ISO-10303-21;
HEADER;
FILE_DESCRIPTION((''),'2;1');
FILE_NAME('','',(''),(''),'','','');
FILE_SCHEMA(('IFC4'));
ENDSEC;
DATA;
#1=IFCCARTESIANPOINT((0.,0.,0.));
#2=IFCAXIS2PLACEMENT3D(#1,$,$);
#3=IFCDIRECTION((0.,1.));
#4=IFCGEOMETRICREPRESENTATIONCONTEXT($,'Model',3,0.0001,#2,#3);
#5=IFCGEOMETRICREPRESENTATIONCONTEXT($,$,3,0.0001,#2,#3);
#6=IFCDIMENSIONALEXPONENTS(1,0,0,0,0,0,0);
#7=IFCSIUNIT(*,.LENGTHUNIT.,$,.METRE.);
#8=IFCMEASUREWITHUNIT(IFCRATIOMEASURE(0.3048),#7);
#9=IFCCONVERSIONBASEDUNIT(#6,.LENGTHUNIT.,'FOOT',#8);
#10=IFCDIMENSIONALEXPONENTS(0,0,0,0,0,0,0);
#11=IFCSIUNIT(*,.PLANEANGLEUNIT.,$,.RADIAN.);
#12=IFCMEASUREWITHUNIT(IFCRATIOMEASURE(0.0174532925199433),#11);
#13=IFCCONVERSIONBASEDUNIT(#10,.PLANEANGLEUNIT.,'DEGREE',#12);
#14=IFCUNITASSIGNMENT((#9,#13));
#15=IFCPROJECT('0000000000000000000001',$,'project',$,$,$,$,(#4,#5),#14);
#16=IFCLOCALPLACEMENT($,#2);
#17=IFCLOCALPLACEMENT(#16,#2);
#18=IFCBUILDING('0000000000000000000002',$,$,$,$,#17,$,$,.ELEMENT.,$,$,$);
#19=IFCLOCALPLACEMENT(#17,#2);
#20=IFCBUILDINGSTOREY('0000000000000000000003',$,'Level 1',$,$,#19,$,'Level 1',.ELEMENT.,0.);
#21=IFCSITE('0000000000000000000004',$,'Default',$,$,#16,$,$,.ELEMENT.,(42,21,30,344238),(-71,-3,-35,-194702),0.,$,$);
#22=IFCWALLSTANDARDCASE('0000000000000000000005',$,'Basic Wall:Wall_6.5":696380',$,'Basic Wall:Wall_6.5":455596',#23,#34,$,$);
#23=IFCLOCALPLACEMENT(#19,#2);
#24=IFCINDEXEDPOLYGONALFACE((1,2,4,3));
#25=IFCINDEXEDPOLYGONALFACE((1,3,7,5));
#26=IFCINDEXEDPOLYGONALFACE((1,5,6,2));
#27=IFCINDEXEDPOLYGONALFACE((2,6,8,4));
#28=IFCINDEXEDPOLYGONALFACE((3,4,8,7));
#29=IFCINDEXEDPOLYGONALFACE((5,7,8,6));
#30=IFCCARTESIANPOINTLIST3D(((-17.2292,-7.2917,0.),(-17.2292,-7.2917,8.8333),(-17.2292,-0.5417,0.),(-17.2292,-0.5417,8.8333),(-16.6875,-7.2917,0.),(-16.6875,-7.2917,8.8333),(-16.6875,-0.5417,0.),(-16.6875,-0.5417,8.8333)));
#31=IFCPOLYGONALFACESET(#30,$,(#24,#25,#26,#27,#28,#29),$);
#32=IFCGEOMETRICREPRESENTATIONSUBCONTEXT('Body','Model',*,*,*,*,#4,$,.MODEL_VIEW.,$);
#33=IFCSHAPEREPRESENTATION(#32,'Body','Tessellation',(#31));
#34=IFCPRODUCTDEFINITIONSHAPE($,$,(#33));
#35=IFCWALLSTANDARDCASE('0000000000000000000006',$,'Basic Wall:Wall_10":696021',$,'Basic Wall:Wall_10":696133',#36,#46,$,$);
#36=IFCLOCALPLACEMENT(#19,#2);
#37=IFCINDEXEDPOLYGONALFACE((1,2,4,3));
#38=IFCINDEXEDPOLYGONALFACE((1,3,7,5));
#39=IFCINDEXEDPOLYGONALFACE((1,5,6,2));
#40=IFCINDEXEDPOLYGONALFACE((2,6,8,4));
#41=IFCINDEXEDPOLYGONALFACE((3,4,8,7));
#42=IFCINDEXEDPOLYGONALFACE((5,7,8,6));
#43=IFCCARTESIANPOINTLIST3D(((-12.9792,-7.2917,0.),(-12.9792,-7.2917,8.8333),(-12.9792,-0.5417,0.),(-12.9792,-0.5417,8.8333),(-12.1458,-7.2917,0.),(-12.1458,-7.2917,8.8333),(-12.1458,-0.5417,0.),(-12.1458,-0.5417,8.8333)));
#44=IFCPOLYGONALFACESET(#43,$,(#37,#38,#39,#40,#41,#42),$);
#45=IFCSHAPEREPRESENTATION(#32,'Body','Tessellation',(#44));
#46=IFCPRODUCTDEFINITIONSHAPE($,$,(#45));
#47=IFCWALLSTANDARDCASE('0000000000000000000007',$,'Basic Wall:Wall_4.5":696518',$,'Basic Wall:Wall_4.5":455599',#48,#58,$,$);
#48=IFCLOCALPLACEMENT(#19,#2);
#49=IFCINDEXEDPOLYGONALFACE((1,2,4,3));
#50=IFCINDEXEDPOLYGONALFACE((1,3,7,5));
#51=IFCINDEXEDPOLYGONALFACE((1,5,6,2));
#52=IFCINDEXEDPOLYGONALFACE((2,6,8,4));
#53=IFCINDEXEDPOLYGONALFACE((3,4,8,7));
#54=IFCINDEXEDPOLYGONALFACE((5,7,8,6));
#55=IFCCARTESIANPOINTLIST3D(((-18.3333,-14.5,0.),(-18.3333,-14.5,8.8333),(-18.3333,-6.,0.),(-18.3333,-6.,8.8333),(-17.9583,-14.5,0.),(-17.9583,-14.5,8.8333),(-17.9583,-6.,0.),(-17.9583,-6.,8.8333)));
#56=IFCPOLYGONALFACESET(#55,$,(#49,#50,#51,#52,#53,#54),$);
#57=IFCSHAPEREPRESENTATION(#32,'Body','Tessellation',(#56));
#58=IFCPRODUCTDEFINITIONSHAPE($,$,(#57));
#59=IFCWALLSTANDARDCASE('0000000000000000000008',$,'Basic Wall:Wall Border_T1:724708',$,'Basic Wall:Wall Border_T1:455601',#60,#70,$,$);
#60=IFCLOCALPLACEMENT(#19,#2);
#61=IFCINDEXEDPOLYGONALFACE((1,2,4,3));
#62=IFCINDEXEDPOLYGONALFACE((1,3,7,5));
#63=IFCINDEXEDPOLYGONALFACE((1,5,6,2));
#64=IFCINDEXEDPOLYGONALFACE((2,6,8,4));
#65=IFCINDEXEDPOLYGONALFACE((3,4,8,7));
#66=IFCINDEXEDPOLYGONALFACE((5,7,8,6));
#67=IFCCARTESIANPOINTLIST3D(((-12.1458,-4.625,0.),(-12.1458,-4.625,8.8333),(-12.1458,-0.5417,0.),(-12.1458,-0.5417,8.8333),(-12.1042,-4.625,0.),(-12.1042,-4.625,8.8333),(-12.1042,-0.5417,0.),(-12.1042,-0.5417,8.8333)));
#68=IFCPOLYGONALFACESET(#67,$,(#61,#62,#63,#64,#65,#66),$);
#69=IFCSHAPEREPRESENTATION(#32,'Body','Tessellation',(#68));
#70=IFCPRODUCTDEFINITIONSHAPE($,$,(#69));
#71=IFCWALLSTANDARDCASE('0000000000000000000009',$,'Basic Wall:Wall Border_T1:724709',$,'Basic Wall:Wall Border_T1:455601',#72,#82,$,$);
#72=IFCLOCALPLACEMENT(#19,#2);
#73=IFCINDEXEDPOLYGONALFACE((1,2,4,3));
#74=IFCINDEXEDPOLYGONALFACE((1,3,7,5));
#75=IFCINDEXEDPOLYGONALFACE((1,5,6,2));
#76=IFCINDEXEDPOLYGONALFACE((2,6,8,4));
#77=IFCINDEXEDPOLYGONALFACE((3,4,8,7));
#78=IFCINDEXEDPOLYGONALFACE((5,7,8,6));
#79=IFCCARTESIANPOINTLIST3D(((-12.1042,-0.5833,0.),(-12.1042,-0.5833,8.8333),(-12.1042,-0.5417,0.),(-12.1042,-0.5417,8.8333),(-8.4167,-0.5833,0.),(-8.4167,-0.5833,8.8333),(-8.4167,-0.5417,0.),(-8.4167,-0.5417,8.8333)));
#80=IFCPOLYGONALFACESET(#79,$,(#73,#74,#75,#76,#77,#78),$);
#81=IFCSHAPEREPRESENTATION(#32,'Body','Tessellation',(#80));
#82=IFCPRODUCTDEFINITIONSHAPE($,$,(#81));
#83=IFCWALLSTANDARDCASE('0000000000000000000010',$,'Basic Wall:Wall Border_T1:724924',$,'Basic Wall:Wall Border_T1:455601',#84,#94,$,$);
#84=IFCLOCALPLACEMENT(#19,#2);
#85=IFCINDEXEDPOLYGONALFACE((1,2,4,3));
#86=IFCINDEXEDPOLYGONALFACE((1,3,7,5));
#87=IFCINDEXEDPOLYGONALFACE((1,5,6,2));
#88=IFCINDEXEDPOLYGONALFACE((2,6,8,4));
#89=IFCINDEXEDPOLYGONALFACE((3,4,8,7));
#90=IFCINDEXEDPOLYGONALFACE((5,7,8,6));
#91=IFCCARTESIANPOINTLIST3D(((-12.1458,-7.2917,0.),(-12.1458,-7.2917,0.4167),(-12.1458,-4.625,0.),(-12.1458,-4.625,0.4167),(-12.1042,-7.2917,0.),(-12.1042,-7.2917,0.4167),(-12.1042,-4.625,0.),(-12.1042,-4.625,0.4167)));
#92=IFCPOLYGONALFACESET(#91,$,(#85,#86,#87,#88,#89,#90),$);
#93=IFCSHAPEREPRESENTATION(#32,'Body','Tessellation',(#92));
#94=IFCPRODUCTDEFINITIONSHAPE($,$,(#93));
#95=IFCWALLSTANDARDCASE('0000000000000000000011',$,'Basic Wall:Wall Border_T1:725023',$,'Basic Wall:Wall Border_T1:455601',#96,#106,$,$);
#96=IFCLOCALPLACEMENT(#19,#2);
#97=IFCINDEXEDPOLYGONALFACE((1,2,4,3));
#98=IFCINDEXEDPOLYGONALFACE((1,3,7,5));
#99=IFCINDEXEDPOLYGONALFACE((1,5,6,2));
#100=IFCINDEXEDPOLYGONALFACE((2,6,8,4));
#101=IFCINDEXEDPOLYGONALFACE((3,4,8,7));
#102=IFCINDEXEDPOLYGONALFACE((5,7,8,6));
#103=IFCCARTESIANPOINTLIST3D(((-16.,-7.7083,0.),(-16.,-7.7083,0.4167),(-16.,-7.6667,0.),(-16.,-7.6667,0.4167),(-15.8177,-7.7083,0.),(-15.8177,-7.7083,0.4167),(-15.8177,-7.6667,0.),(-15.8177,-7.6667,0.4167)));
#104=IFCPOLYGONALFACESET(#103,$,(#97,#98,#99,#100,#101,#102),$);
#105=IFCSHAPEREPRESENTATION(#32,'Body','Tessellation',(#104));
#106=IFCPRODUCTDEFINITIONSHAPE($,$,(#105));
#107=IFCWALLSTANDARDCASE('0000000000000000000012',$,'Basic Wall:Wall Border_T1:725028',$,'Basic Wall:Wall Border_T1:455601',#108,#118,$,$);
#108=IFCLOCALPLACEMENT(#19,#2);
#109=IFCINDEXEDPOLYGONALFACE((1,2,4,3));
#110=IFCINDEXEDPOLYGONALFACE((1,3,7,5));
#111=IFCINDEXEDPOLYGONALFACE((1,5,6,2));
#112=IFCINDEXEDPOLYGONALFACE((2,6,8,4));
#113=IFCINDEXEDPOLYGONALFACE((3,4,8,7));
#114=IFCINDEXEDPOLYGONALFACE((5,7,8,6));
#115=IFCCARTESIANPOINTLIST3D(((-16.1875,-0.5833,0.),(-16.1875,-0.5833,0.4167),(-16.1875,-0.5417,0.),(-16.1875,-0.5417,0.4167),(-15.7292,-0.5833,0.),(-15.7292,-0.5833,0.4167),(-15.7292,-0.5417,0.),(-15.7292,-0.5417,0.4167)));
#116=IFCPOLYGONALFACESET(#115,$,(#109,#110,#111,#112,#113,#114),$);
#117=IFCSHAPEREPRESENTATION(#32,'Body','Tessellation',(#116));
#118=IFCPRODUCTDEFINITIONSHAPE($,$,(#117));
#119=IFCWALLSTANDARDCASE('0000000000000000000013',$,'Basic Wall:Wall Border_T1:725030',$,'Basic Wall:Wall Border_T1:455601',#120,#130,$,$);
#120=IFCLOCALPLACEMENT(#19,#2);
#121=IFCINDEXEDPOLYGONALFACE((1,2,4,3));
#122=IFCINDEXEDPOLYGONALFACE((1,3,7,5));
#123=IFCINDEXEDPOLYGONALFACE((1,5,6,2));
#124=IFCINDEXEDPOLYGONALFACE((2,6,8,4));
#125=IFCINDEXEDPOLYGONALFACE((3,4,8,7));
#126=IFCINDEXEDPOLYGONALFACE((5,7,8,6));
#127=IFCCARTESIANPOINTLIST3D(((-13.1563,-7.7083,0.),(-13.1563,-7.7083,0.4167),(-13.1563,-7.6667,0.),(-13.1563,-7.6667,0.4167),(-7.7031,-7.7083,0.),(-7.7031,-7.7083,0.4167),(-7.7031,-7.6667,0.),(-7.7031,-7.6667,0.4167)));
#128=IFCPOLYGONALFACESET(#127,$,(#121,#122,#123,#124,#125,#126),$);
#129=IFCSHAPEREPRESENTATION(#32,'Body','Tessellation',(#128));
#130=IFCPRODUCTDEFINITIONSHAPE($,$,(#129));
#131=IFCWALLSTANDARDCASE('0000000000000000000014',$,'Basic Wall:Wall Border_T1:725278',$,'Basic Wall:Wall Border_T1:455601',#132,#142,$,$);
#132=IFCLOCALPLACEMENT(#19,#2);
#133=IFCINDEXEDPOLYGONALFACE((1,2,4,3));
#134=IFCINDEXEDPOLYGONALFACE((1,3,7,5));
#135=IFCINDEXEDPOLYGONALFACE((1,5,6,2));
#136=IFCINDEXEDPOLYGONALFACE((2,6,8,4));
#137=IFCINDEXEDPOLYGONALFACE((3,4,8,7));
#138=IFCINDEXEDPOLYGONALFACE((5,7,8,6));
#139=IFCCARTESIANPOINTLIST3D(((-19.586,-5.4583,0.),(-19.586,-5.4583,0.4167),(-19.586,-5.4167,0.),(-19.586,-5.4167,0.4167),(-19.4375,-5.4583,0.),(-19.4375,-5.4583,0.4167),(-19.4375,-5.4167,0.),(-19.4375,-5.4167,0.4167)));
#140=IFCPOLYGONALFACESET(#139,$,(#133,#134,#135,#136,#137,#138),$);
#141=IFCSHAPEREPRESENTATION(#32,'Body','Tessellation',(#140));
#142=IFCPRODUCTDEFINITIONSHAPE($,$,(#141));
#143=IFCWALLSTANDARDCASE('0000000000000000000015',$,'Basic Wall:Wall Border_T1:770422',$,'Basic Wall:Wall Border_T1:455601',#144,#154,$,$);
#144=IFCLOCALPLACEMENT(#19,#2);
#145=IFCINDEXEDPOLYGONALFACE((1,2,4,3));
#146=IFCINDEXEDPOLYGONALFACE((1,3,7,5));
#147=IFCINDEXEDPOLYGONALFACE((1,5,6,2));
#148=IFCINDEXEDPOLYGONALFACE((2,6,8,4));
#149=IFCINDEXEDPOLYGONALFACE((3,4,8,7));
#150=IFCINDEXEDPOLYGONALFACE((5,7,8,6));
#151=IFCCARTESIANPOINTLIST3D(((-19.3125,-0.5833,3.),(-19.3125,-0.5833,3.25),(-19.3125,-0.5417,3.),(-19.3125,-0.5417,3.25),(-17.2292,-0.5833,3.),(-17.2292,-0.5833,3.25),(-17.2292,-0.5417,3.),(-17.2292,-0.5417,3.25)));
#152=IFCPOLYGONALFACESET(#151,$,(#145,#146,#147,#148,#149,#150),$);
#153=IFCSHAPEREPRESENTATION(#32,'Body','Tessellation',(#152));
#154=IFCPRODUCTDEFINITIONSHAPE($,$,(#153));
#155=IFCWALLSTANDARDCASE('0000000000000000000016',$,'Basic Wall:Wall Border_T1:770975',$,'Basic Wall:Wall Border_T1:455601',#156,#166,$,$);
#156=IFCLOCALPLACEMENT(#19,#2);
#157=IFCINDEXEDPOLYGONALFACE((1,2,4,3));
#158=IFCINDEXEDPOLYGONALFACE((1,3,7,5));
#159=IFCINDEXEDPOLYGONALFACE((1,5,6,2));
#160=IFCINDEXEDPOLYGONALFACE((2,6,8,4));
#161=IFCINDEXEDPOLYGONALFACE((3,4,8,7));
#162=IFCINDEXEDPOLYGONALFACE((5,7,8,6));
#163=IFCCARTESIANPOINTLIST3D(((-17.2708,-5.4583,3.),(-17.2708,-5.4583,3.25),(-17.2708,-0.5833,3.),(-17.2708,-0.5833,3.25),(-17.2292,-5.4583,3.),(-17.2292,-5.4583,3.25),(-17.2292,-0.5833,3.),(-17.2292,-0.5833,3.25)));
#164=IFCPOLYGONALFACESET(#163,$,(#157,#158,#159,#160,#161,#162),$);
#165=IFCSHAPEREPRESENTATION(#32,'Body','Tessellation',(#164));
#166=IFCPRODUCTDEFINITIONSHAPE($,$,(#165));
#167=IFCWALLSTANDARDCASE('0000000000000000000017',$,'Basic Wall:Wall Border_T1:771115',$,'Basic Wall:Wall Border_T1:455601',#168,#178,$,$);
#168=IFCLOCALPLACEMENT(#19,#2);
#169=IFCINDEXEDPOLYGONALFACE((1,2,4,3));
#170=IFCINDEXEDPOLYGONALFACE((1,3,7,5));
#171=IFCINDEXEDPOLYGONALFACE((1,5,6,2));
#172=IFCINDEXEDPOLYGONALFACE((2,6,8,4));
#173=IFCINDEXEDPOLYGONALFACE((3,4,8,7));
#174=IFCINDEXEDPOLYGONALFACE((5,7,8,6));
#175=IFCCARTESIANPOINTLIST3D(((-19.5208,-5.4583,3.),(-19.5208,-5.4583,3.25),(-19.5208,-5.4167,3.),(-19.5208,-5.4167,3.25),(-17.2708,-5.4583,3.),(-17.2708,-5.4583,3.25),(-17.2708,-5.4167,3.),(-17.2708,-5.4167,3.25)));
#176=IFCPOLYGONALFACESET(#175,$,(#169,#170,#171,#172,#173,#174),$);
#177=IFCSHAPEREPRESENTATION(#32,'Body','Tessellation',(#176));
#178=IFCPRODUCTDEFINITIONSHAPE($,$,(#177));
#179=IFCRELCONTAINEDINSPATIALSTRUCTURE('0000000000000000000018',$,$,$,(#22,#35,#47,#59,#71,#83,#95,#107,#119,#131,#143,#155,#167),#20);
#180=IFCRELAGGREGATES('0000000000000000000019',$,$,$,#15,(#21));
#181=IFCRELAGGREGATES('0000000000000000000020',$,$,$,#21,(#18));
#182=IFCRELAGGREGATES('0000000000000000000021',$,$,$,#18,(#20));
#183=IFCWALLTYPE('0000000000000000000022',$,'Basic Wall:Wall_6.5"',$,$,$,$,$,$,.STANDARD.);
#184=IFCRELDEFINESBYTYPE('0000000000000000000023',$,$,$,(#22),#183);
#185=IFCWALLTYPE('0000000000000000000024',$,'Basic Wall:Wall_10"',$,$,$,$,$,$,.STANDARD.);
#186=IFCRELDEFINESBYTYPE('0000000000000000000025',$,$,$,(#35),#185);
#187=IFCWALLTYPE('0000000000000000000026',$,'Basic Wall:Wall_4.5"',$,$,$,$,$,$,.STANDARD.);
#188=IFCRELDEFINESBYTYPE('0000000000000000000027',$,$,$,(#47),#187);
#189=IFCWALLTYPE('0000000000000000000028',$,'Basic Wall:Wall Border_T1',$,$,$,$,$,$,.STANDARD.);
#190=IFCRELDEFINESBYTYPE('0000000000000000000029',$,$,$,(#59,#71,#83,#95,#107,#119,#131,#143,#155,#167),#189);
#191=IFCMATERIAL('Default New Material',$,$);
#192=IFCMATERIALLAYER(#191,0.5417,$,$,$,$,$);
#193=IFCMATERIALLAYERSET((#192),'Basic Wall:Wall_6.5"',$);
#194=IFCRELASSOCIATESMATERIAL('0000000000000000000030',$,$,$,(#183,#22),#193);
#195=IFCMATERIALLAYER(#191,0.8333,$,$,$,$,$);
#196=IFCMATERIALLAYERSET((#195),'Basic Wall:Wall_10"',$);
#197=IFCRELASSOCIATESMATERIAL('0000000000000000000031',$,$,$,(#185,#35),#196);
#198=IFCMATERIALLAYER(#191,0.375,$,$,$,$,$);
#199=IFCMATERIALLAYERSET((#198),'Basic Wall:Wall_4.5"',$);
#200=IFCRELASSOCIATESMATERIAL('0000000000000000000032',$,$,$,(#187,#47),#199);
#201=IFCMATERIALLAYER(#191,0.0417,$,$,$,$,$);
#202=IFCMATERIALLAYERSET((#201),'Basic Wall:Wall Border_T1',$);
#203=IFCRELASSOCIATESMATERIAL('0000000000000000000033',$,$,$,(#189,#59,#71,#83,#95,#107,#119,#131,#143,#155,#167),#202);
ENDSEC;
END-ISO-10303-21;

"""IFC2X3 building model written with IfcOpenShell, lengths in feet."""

from ifc_helpers import new_model, entity, si_unit, converted_unit, direction, frame, frame_2d, origin, place, context, subcontext, project, spatial, rectangle, extrude, material, layer, layer_set, layer_usage, type_object, element, save


model = new_model("IFC2X3")

# Units and contexts
model_context = context("Model", 3, precision=0.0001, world=origin(), true_north=direction((0.0, 1.0)))
context_of_model = context(None, 3, precision=0.0001, world=origin(), true_north=direction((0.0, 1.0)))
body_context = subcontext(model_context, "Body", "Model", "MODEL_VIEW")
ifc_project = project(units=[converted_unit("LENGTHUNIT", "FOOT", entity("IfcRatioMeasure", 0.3048), si_unit("LENGTHUNIT", "METRE"), dimensions=[1, 0, 0, 0, 0, 0, 0]), converted_unit("PLANEANGLEUNIT", "DEGREE", entity("IfcRatioMeasure", 0.0174532925199433), si_unit("PLANEANGLEUNIT", "RADIAN"), dimensions=[0, 0, 0, 0, 0, 0, 0])], contexts=[model_context, context_of_model])

# Site, building, storey
site_placement = place(None, origin())
site = spatial("IfcSite", under=ifc_project, at=site_placement, Name="Default", CompositionType="ELEMENT", RefLatitude=(42, 21, 30, 344238), RefLongitude=(-71, -3, -35, -194702), RefElevation=0.0)
building_placement = place(site_placement, origin())
building = spatial("IfcBuilding", under=site, at=building_placement, CompositionType="ELEMENT")
storey_placement = place(building_placement, origin())
storey = spatial("IfcBuildingStorey", under=building, at=storey_placement, Name="Level 1", LongName="Level 1", CompositionType="ELEMENT", Elevation=0.0)

# Wall
ifc_material_1 = material(Name="Default New Material")
ifc_layer_1 = layer(ifc_material_1, 0.5417)
ifc_layer_set_1 = layer_set([ifc_layer_1], Name="Basic Wall:Wall_6.5\"")
ifc_layer_usage_1 = layer_usage(ifc_layer_set_1, "AXIS2", "POSITIVE", -0.2708)
wall_type_1 = type_object("IfcWallType", Name="Basic Wall:Wall_6.5\"", PredefinedType="STANDARD", material=ifc_layer_set_1)
wall_1_placement = place(storey_placement, frame((-16.9583, -7.2917, 0.0), z_axis=(0.0, 0.0, 1.0), x_axis=(0.0, 1.0, 0.0)))
element("IfcWallStandardCase", 1, at=wall_1_placement, inside=storey, type_object=wall_type_1, material=ifc_layer_usage_1, Name="Basic Wall:Wall_6.5\":696380", ObjectType="Basic Wall:Wall_6.5\":455596", context=body_context, shape_type="SweptSolid", body=[
    extrude(rectangle(XDim=6.75, YDim=0.5417, at=frame_2d((3.375, 0.0), x_axis=(-1.0, 0.0))), origin(), (0.0, 0.0, 1.0), 8.8333),
])

# Walls
ifc_layer_2 = layer(ifc_material_1, 0.8333)
ifc_layer_set_2 = layer_set([ifc_layer_2], Name="Basic Wall:Wall_10\"")
ifc_layer_usage_2 = layer_usage(ifc_layer_set_2, "AXIS2", "NEGATIVE", 0.4167)
wall_type_2 = type_object("IfcWallType", Name="Basic Wall:Wall_10\"", PredefinedType="STANDARD", material=ifc_layer_set_2)
wall_2_placement = place(storey_placement, frame((-12.5625, -7.2917, 0.0), z_axis=(0.0, 0.0, 1.0), x_axis=(0.0, 1.0, 0.0)))
element("IfcWallStandardCase", 2, at=wall_2_placement, inside=storey, type_object=wall_type_2, material=ifc_layer_usage_2, Name="Basic Wall:Wall_10\":696021", ObjectType="Basic Wall:Wall_10\":696133", context=body_context, shape_type="SweptSolid", body=[
    extrude(rectangle(XDim=6.75, YDim=0.8333, at=frame_2d((3.375, 0.0), x_axis=(-1.0, 0.0))), origin(), (0.0, 0.0, 1.0), 8.8333),
])
ifc_layer_3 = layer(ifc_material_1, 0.375)
ifc_layer_set_3 = layer_set([ifc_layer_3], Name="Basic Wall:Wall_4.5\"")
ifc_layer_usage_3 = layer_usage(ifc_layer_set_3, "AXIS2", "POSITIVE", -0.1875)
wall_type_3 = type_object("IfcWallType", Name="Basic Wall:Wall_4.5\"", PredefinedType="STANDARD", material=ifc_layer_set_3)
wall_3_placement = place(storey_placement, frame((-18.1458, -6.0, 0.0), z_axis=(0.0, 0.0, 1.0), x_axis=(0.0, -1.0, 0.0)))
element("IfcWallStandardCase", 3, at=wall_3_placement, inside=storey, type_object=wall_type_3, material=ifc_layer_usage_3, Name="Basic Wall:Wall_4.5\":696518", ObjectType="Basic Wall:Wall_4.5\":455599", context=body_context, shape_type="SweptSolid", body=[
    extrude(rectangle(XDim=8.5, YDim=0.375, at=frame_2d((4.25, 0.0), x_axis=(-1.0, 0.0))), origin(), (0.0, 0.0, 1.0), 8.8333),
])
ifc_layer_4 = layer(ifc_material_1, 0.0417)
ifc_layer_set_4 = layer_set([ifc_layer_4], Name="Basic Wall:Wall Border_T1")
ifc_layer_usage_4 = layer_usage(ifc_layer_set_4, "AXIS2", "POSITIVE", -0.0208)
wall_type_4 = type_object("IfcWallType", Name="Basic Wall:Wall Border_T1", PredefinedType="STANDARD", material=ifc_layer_set_4)
wall_4_placement = place(storey_placement, frame((-12.125, -4.625, 0.0), z_axis=(0.0, 0.0, 1.0), x_axis=(0.0, 1.0, 0.0)))
element("IfcWallStandardCase", 4, at=wall_4_placement, inside=storey, type_object=wall_type_4, material=ifc_layer_usage_4, Name="Basic Wall:Wall Border_T1:724708", ObjectType="Basic Wall:Wall Border_T1:455601", context=body_context, shape_type="SweptSolid", body=[
    extrude(rectangle(XDim=4.0833, YDim=0.0417, at=frame_2d((2.0417, 0.0), x_axis=(-1.0, 0.0))), origin(), (0.0, 0.0, 1.0), 8.8333),
])
ifc_layer_usage_5 = layer_usage(ifc_layer_set_4, "AXIS2", "POSITIVE", -0.0208)
wall_5_placement = place(storey_placement, frame((-12.1042, -0.5625, 0.0)))
element("IfcWallStandardCase", 5, at=wall_5_placement, inside=storey, type_object=wall_type_4, material=ifc_layer_usage_5, Name="Basic Wall:Wall Border_T1:724709", ObjectType="Basic Wall:Wall Border_T1:455601", context=body_context, shape_type="SweptSolid", body=[
    extrude(rectangle(XDim=3.6875, YDim=0.0417, at=frame_2d((1.8438, 0.0), x_axis=(-1.0, 0.0))), origin(), (0.0, 0.0, 1.0), 8.8333),
])
ifc_layer_usage_6 = layer_usage(ifc_layer_set_4, "AXIS2", "POSITIVE", -0.0208)
wall_6_placement = place(storey_placement, frame((-12.125, -7.2917, 0.0), z_axis=(0.0, 0.0, 1.0), x_axis=(0.0, 1.0, 0.0)))
element("IfcWallStandardCase", 6, at=wall_6_placement, inside=storey, type_object=wall_type_4, material=ifc_layer_usage_6, Name="Basic Wall:Wall Border_T1:724924", ObjectType="Basic Wall:Wall Border_T1:455601", context=body_context, shape_type="SweptSolid", body=[
    extrude(rectangle(XDim=2.6667, YDim=0.0417, at=frame_2d((1.3333, 0.0), x_axis=(-1.0, 0.0))), origin(), (0.0, 0.0, 1.0), 0.4167),
])
ifc_layer_usage_7 = layer_usage(ifc_layer_set_4, "AXIS2", "POSITIVE", -0.0208)
wall_7_placement = place(storey_placement, frame((-16.0, -7.6875, 0.0)))
element("IfcWallStandardCase", 7, at=wall_7_placement, inside=storey, type_object=wall_type_4, material=ifc_layer_usage_7, Name="Basic Wall:Wall Border_T1:725023", ObjectType="Basic Wall:Wall Border_T1:455601", context=body_context, shape_type="SweptSolid", body=[
    extrude(rectangle(XDim=0.1823, YDim=0.0417, at=frame_2d((0.0912, 0.0), x_axis=(-1.0, 0.0))), origin(), (0.0, 0.0, 1.0), 0.4167),
])
ifc_layer_usage_8 = layer_usage(ifc_layer_set_4, "AXIS2", "POSITIVE", -0.0208)
wall_8_placement = place(storey_placement, frame((-16.1875, -0.5625, 0.0)))
element("IfcWallStandardCase", 8, at=wall_8_placement, inside=storey, type_object=wall_type_4, material=ifc_layer_usage_8, Name="Basic Wall:Wall Border_T1:725028", ObjectType="Basic Wall:Wall Border_T1:455601", context=body_context, shape_type="SweptSolid", body=[
    extrude(rectangle(XDim=0.4583, YDim=0.0417, at=frame_2d((0.2292, 0.0), x_axis=(-1.0, 0.0))), origin(), (0.0, 0.0, 1.0), 0.4167),
])
ifc_layer_usage_9 = layer_usage(ifc_layer_set_4, "AXIS2", "POSITIVE", -0.0208)
wall_9_placement = place(storey_placement, frame((-13.1562, -7.6875, 0.0)))
element("IfcWallStandardCase", 9, at=wall_9_placement, inside=storey, type_object=wall_type_4, material=ifc_layer_usage_9, Name="Basic Wall:Wall Border_T1:725030", ObjectType="Basic Wall:Wall Border_T1:455601", context=body_context, shape_type="SweptSolid", body=[
    extrude(rectangle(XDim=5.4532, YDim=0.0417, at=frame_2d((2.7266, 0.0), x_axis=(-1.0, 0.0))), origin(), (0.0, 0.0, 1.0), 0.4167),
])
ifc_layer_usage_10 = layer_usage(ifc_layer_set_4, "AXIS2", "POSITIVE", -0.0208)
wall_10_placement = place(storey_placement, frame((-19.4375, -5.4375, 0.0), z_axis=(0.0, 0.0, 1.0), x_axis=(-1.0, 0.0, 0.0)))
element("IfcWallStandardCase", 10, at=wall_10_placement, inside=storey, type_object=wall_type_4, material=ifc_layer_usage_10, Name="Basic Wall:Wall Border_T1:725278", ObjectType="Basic Wall:Wall Border_T1:455601", context=body_context, shape_type="SweptSolid", body=[
    extrude(rectangle(XDim=0.1485, YDim=0.0417, at=frame_2d((0.0742, 0.0), x_axis=(-1.0, 0.0))), origin(), (0.0, 0.0, 1.0), 0.4167),
])
ifc_layer_usage_11 = layer_usage(ifc_layer_set_4, "AXIS2", "POSITIVE", -0.0208)
wall_11_placement = place(storey_placement, frame((-19.3125, -0.5625, 3.0)))
element("IfcWallStandardCase", 11, at=wall_11_placement, inside=storey, type_object=wall_type_4, material=ifc_layer_usage_11, Name="Basic Wall:Wall Border_T1:770422", ObjectType="Basic Wall:Wall Border_T1:455601", context=body_context, shape_type="SweptSolid", body=[
    extrude(rectangle(XDim=2.0833, YDim=0.0417, at=frame_2d((1.0417, 0.0), x_axis=(-1.0, 0.0))), origin(), (0.0, 0.0, 1.0), 0.25),
])
ifc_layer_usage_12 = layer_usage(ifc_layer_set_4, "AXIS2", "POSITIVE", -0.0208)
wall_12_placement = place(storey_placement, frame((-17.25, -0.5833, 3.0), z_axis=(0.0, 0.0, 1.0), x_axis=(0.0, -1.0, 0.0)))
element("IfcWallStandardCase", 12, at=wall_12_placement, inside=storey, type_object=wall_type_4, material=ifc_layer_usage_12, Name="Basic Wall:Wall Border_T1:770975", ObjectType="Basic Wall:Wall Border_T1:455601", context=body_context, shape_type="SweptSolid", body=[
    extrude(rectangle(XDim=4.875, YDim=0.0417, at=frame_2d((2.4375, 0.0), x_axis=(-1.0, 0.0))), origin(), (0.0, 0.0, 1.0), 0.25),
])
ifc_layer_usage_13 = layer_usage(ifc_layer_set_4, "AXIS2", "POSITIVE", -0.0208)
wall_13_placement = place(storey_placement, frame((-17.2708, -5.4375, 3.0), z_axis=(0.0, 0.0, 1.0), x_axis=(-1.0, 0.0, 0.0)))
element("IfcWallStandardCase", 13, at=wall_13_placement, inside=storey, type_object=wall_type_4, material=ifc_layer_usage_13, Name="Basic Wall:Wall Border_T1:771115", ObjectType="Basic Wall:Wall Border_T1:455601", context=body_context, shape_type="SweptSolid", body=[
    extrude(rectangle(XDim=2.25, YDim=0.0417, at=frame_2d((1.125, 0.0), x_axis=(-1.0, 0.0))), origin(), (0.0, 0.0, 1.0), 0.25),
])

save(model, "model.ifc")
